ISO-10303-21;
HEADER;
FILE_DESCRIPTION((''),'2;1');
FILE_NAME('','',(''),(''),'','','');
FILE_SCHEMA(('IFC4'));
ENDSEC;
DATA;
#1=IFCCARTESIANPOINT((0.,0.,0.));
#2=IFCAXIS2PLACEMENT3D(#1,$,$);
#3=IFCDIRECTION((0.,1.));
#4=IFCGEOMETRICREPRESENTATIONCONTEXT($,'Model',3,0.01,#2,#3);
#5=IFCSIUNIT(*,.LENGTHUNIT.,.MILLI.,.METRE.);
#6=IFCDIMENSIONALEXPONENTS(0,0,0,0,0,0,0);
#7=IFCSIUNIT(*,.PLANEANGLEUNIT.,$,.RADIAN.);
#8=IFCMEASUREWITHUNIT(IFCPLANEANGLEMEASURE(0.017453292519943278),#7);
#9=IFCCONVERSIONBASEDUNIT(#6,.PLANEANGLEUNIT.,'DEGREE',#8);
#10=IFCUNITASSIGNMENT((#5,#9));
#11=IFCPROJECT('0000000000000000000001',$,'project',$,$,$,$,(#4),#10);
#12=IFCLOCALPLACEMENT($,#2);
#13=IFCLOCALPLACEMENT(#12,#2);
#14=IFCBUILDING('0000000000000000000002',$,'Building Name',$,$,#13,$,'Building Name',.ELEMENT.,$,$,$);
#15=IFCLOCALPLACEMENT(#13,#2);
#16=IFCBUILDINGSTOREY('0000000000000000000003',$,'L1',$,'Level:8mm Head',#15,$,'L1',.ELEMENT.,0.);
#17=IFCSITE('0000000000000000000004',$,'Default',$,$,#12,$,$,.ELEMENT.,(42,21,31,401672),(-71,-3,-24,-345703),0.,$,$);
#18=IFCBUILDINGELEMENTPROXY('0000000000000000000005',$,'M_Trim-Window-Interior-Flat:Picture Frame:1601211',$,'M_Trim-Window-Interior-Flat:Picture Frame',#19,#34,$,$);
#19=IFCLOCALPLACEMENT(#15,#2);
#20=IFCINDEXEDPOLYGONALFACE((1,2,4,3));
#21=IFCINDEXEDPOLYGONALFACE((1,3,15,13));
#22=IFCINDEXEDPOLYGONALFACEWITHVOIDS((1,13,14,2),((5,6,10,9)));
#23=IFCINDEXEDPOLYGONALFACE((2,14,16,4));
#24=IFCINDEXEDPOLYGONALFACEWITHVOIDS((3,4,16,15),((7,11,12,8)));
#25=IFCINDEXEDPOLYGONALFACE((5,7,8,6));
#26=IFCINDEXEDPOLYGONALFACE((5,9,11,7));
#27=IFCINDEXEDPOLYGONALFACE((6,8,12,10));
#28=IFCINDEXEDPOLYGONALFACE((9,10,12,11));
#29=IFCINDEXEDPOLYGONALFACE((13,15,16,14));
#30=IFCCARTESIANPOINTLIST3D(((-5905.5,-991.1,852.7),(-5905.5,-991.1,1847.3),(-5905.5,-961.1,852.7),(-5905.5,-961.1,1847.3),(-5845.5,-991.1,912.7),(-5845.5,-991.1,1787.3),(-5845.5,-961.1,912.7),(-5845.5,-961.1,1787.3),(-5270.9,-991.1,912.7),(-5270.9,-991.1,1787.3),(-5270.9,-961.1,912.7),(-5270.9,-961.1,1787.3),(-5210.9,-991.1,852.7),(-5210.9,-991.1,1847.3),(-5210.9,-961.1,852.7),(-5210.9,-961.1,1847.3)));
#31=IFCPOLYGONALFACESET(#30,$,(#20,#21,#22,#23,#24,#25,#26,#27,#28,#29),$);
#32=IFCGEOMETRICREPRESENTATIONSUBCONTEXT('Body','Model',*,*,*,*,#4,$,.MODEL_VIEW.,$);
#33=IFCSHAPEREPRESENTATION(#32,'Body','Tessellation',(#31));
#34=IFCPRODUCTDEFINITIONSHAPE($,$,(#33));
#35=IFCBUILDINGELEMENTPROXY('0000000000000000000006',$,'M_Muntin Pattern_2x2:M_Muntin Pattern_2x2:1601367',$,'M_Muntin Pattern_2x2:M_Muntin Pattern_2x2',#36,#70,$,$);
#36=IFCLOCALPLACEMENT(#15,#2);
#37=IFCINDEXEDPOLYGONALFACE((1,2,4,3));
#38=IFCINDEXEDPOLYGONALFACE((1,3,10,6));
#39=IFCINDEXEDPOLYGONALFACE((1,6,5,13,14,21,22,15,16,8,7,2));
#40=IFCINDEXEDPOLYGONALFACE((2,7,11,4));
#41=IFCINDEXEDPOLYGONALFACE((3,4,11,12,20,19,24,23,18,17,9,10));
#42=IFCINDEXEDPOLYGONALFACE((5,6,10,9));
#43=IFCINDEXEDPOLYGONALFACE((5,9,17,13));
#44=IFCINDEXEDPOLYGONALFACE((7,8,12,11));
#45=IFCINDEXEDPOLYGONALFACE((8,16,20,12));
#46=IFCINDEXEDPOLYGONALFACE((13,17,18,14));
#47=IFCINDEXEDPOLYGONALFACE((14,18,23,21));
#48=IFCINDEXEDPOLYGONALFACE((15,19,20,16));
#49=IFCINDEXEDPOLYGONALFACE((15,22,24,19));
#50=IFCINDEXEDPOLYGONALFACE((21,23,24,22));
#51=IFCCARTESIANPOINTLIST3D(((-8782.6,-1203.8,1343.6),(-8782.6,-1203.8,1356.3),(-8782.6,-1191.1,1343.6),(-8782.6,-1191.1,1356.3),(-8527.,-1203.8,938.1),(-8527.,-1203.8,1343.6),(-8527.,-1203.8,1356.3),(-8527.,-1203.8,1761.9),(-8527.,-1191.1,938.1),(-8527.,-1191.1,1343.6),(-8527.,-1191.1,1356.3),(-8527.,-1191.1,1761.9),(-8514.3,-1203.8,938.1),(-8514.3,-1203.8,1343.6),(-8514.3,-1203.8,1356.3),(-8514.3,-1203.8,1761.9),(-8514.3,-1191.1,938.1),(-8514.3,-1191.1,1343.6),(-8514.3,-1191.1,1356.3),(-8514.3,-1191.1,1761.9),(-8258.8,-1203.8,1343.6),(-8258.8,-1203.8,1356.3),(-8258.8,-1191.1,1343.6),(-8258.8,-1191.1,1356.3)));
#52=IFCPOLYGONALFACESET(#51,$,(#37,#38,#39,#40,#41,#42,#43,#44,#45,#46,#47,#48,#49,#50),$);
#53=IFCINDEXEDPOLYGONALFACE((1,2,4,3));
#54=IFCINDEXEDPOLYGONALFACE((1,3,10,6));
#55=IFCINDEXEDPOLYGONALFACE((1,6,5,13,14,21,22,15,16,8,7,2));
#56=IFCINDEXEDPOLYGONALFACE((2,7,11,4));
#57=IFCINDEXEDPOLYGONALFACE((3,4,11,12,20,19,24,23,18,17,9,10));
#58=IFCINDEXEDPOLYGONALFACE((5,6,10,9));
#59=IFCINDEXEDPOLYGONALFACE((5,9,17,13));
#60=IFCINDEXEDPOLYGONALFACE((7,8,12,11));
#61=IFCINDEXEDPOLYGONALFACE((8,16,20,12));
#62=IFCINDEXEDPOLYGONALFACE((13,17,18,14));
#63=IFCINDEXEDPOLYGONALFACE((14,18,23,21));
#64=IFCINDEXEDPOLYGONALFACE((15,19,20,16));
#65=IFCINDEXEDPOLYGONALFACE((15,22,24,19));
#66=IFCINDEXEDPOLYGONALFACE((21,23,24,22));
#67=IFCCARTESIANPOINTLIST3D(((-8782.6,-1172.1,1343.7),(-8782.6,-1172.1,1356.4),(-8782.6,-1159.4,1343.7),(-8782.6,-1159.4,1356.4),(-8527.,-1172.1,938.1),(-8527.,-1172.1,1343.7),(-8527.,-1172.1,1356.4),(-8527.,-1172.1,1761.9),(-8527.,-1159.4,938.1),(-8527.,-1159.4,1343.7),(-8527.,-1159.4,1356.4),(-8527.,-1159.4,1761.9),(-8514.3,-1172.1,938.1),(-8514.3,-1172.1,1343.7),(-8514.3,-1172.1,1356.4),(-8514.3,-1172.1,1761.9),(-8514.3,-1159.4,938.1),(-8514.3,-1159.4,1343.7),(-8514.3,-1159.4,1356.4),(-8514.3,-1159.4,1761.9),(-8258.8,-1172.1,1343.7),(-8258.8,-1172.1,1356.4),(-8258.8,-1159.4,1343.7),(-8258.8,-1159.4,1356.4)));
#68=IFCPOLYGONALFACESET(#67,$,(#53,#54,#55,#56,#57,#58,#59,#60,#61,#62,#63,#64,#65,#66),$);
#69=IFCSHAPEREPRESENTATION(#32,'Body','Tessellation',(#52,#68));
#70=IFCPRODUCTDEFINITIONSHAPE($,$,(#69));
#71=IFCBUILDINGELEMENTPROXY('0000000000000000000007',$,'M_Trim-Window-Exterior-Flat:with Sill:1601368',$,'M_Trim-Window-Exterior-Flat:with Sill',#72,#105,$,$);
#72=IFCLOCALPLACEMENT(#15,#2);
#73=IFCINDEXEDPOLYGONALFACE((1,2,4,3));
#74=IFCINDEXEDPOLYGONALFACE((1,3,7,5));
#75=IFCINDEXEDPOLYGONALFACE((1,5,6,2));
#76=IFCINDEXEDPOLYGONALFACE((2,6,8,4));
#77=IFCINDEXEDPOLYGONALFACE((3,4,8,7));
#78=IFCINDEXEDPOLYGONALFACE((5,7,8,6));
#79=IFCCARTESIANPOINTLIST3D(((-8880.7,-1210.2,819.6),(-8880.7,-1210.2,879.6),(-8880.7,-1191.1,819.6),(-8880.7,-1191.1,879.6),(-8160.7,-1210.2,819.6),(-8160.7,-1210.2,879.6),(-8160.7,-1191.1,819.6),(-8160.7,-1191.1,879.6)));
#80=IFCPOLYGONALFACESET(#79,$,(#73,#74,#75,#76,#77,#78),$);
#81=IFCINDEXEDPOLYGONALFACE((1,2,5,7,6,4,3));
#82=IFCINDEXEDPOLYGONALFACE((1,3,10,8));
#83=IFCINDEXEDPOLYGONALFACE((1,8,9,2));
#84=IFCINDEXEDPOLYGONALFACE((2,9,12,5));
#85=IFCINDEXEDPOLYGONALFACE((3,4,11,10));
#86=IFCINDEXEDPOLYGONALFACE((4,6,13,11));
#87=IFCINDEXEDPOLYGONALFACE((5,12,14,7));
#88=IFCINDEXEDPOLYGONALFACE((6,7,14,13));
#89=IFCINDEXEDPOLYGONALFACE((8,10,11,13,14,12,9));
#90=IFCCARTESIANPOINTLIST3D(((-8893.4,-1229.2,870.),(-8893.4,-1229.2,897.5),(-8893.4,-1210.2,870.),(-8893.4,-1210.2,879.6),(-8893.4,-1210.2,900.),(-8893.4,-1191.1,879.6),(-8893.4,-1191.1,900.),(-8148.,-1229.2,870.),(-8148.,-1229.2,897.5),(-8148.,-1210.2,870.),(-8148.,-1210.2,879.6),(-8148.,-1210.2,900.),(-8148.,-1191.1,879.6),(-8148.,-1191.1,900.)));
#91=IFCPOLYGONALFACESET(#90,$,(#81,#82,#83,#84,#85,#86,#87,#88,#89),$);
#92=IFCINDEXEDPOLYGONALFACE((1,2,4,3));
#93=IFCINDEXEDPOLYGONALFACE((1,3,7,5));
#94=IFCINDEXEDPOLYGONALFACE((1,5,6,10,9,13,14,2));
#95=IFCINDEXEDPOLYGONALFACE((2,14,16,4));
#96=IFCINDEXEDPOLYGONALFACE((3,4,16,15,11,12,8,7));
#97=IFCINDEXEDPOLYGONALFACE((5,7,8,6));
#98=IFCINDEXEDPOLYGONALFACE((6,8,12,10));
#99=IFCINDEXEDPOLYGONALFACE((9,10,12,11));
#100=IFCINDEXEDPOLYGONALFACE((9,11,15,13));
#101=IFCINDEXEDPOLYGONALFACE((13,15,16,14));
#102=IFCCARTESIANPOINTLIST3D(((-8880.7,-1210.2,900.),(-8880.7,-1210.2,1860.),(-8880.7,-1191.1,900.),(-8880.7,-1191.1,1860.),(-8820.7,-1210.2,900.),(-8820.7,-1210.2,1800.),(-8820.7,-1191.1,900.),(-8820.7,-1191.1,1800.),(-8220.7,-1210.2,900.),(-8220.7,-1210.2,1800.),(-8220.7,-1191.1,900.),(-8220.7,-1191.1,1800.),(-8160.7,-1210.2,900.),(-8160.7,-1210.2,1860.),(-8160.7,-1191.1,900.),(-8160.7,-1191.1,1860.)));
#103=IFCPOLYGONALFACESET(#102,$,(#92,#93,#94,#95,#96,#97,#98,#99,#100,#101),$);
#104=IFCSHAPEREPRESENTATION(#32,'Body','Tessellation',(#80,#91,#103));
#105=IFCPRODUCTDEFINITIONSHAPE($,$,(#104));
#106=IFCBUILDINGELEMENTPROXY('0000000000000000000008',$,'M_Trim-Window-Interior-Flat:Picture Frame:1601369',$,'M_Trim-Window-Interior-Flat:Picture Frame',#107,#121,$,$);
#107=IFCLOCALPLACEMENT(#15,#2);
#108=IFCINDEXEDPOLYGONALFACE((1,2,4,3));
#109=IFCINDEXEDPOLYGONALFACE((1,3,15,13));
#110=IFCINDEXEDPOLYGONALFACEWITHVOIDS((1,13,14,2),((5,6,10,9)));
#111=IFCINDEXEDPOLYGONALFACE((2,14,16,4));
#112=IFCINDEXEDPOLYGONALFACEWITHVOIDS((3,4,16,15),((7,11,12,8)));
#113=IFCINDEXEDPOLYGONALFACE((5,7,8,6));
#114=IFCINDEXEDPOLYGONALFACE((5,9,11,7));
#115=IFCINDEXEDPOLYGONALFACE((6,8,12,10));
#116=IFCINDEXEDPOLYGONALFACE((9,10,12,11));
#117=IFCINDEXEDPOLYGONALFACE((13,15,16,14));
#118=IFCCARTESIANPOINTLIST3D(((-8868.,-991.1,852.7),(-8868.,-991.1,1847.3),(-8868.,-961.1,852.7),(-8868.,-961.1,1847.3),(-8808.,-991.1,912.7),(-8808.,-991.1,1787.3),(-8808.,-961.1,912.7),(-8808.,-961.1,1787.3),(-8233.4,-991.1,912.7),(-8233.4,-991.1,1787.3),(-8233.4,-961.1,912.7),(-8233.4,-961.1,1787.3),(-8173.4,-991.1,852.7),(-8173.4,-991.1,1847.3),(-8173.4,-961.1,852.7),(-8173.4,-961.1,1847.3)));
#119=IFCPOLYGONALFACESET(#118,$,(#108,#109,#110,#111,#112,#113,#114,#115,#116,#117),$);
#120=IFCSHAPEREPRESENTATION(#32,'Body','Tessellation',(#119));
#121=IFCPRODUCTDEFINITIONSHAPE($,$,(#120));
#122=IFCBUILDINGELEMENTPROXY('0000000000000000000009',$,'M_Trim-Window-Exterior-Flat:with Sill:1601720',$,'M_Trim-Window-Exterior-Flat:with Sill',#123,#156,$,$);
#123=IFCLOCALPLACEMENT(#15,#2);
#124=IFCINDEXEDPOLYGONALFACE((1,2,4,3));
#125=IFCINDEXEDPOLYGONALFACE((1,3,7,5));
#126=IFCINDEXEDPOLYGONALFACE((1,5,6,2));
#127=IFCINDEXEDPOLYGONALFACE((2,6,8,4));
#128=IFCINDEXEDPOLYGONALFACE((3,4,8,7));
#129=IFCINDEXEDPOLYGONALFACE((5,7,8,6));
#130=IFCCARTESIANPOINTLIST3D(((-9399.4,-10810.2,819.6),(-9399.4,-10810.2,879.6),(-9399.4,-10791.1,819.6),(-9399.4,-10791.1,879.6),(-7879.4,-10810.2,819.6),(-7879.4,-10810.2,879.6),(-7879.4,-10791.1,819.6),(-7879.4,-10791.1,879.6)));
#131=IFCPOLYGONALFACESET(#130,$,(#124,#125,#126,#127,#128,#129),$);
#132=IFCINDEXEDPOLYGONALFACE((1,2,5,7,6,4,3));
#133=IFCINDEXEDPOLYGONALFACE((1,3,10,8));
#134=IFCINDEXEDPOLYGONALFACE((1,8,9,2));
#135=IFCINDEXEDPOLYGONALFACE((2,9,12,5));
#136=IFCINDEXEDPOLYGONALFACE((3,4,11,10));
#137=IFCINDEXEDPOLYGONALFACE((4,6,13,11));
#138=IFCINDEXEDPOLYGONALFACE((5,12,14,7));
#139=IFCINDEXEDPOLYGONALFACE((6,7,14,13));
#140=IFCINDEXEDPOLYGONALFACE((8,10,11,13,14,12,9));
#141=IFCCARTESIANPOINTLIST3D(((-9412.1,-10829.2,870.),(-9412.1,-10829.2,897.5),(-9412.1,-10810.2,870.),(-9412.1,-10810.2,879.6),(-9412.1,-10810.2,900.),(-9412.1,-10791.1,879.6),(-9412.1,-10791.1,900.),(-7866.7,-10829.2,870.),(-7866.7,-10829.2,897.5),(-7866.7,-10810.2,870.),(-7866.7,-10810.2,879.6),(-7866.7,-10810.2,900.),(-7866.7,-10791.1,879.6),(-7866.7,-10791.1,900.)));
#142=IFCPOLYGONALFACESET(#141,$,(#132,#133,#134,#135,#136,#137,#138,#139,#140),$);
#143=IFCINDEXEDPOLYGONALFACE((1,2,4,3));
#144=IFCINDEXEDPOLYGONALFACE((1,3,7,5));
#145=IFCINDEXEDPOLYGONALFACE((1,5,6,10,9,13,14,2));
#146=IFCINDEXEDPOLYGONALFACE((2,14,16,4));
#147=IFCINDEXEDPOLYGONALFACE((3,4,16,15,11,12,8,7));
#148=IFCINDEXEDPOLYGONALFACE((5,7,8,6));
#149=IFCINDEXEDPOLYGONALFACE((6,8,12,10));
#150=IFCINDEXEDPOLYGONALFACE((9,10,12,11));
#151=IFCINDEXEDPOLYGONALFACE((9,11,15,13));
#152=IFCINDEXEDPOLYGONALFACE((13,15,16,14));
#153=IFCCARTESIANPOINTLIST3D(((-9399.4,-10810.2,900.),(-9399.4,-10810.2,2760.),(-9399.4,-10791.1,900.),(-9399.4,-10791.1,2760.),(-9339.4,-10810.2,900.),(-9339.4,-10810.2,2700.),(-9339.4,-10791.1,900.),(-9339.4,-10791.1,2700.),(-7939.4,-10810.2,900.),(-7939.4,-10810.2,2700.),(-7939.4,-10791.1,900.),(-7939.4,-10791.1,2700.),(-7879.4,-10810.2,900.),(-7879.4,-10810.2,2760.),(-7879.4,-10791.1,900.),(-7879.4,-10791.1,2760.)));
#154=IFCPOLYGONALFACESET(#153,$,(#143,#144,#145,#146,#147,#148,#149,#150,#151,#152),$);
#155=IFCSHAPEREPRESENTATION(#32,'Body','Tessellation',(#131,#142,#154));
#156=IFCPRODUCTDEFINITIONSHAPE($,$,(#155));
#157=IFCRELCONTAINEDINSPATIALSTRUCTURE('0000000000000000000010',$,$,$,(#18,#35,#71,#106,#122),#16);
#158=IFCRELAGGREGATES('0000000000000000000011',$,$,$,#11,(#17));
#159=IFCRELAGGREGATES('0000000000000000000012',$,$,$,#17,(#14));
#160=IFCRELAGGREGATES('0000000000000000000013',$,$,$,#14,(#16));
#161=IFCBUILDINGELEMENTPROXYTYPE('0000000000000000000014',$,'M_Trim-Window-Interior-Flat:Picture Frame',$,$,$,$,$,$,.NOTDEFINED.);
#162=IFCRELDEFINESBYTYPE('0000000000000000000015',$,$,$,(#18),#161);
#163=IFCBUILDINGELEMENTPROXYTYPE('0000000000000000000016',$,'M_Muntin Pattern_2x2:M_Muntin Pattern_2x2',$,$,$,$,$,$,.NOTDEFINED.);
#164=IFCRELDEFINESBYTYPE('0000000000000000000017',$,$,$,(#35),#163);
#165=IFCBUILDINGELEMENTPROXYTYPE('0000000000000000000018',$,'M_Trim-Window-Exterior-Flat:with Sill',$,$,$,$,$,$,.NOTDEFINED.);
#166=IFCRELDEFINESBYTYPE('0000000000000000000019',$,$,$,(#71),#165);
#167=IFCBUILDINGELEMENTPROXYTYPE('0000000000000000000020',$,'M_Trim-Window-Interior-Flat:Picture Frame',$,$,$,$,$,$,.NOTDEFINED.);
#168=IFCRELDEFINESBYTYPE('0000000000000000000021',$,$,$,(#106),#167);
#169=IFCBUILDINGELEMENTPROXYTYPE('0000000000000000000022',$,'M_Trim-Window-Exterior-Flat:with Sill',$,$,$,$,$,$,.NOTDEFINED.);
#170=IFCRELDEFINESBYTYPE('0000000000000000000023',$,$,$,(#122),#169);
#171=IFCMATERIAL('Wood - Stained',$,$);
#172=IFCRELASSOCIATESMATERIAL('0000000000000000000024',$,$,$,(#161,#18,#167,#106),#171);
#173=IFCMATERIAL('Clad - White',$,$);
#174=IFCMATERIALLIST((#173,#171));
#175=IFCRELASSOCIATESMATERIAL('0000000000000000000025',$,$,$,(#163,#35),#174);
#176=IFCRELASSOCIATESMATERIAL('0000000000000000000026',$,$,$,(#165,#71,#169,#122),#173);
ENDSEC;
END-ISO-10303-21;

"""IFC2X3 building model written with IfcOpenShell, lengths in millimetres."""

from ifc_helpers import new_model, entity, si_unit, converted_unit, direction, frame, frame_2d, origin, place, context, subcontext, project, spatial, polyline, rectangle, outline, extrude, source, transform, mapped, material, material_list, type_object, type_shapes, element, save


model = new_model("IFC2X3")

# Units and contexts
model_context = context("Model", 3, precision=0.01, world=origin(), true_north=direction((0.0, 1.0)))
body_context = subcontext(model_context, "Body", "Model", "MODEL_VIEW")
ifc_project = project(units=[si_unit("LENGTHUNIT", "METRE", prefix="MILLI"), converted_unit("PLANEANGLEUNIT", "DEGREE", entity("IfcPlaneAngleMeasure", 0.017453292519943278), si_unit("PLANEANGLEUNIT", "RADIAN"), dimensions=[0, 0, 0, 0, 0, 0, 0])], contexts=[model_context])

# Site, building, storey
site_placement = place(None, origin())
site = spatial("IfcSite", under=ifc_project, at=site_placement, Name="Default", CompositionType="ELEMENT", RefLatitude=(42, 21, 31, 401672), RefLongitude=(-71, -3, -24, -345703), RefElevation=0.0)
building_placement = place(site_placement, origin())
building = spatial("IfcBuilding", under=site, at=building_placement, Name="Building Name", LongName="Building Name", CompositionType="ELEMENT")
storey_placement = place(building_placement, origin())
storey = spatial("IfcBuildingStorey", under=building, at=storey_placement, Name="L1", ObjectType="Level:8mm Head", LongName="L1", CompositionType="ELEMENT", Elevation=0.0)

# Building element proxies
ifc_material_1 = material(Name="Clad - White")
ifc_material_2 = material(Name="Wood - Stained")
ifc_material_list = material_list([ifc_material_1, ifc_material_2])
building_element_proxy_type_1 = type_object("IfcBuildingElementProxyType", Name="M_Trim-Window-Interior-Flat:Picture Frame", PredefinedType="NOTDEFINED", material=ifc_material_2)
shared_shape_1 = source(origin(), body_context, "Body", "SweptSolid", [
    extrude(outline(polyline([(-497.3, -347.3), (497.3, -347.3), (497.3, 347.3), (-497.3, 347.3), (-497.3, -347.3)]), holes=[polyline([(-437.3, -287.3), (-437.3, 287.3), (437.3, 287.3), (437.3, -287.3), (-437.3, -287.3)])]), frame((0.0, 450.0, 0.0), z_axis=(0.0, 0.0, 1.0), x_axis=(0.0, 1.0, 0.0)), (0.0, 0.0, 1.0), 30.0),
])
type_shapes(building_element_proxy_type_1, [shared_shape_1])
proxy_1_placement = place(storey_placement, frame((-5558.2, -991.1, 1800.0), z_axis=(0.0, 1.0, 0.0), x_axis=(1.0, 0.0, 0.0)))
element("IfcBuildingElementProxy", 1, at=proxy_1_placement, inside=storey, type_object=building_element_proxy_type_1, material=ifc_material_2, Name="M_Trim-Window-Interior-Flat:Picture Frame:1601211", ObjectType="M_Trim-Window-Interior-Flat:Picture Frame", context=body_context, shape_type="MappedRepresentation", body=[
    mapped(shared_shape_1, transform((0.0, 0.0, 0.0), scale=1.0)),
])
building_element_proxy_type_2 = type_object("IfcBuildingElementProxyType", Name="M_Muntin Pattern_2x2:M_Muntin Pattern_2x2", PredefinedType="NOTDEFINED", material=ifc_material_list)
shared_shape_2 = source(origin(), body_context, "Body", "SweptSolid", [
    extrude(outline(polyline([(6.4, -6.4), (411.9, -6.4), (411.9, 6.3), (6.4, 6.3), (6.4, 261.9), (-6.3, 261.9), (-6.3, 6.3), (-411.9, 6.3), (-411.9, -6.4), (-6.3, -6.4), (-6.3, -261.9), (6.4, -261.9), (6.4, -6.4)])), frame((0.0, -22.2, 411.9), z_axis=(0.0, 1.0, 0.0), x_axis=(0.0, 0.0, 1.0)), (0.0, 0.0, 1.0), 12.7),
    extrude(outline(polyline([(6.4, -6.4), (411.9, -6.4), (411.9, 6.3), (6.4, 6.3), (6.4, 261.9), (-6.3, 261.9), (-6.3, 6.3), (-411.9, 6.3), (-411.9, -6.4), (-6.3, -6.4), (-6.3, -261.9), (6.4, -261.9), (6.4, -6.4)])), frame((0.0, 9.5, 411.9), z_axis=(0.0, 1.0, 0.0), x_axis=(0.0, 0.0, 1.0)), (0.0, 0.0, 1.0), 12.7),
])
type_shapes(building_element_proxy_type_2, [shared_shape_2])
proxy_2_placement = place(storey_placement, frame((-8520.7, -1181.6, 938.1)))
element("IfcBuildingElementProxy", 2, at=proxy_2_placement, inside=storey, type_object=building_element_proxy_type_2, material=ifc_material_list, Name="M_Muntin Pattern_2x2:M_Muntin Pattern_2x2:1601367", ObjectType="M_Muntin Pattern_2x2:M_Muntin Pattern_2x2", context=body_context, shape_type="MappedRepresentation", body=[
    mapped(shared_shape_2, transform((0.0, 0.0, 0.0), scale=1.0)),
])
building_element_proxy_type_3 = type_object("IfcBuildingElementProxyType", Name="M_Trim-Window-Exterior-Flat:with Sill", PredefinedType="NOTDEFINED", material=ifc_material_1)
shared_shape_3 = source(origin(), body_context, "Body", "SweptSolid", [
    extrude(rectangle(XDim=720.0, YDim=60.0, at=frame_2d((0.0, 0.0), x_axis=(1.0, 0.0))), frame((0.0, -950.4, 0.0), z_axis=(0.0, 0.0, 1.0), x_axis=(-1.0, 0.0, 0.0)), (0.0, 0.0, 1.0), 19.0),
    extrude(outline(polyline([(-19.0, -15.2), (0.0, -15.2), (0.0, -5.7), (19.0, -5.7), (19.0, 14.8), (0.0, 14.8), (-19.0, 12.3), (-19.0, -15.2)])), frame((-372.7, -914.8, 19.0), z_axis=(1.0, 0.0, 0.0), x_axis=(0.0, 0.0, -1.0)), (0.0, 0.0, 1.0), 745.4),
    extrude(outline(polyline([(-495.0, -360.0), (465.0, -360.0), (465.0, -300.0), (-435.0, -300.0), (-435.0, 300.0), (465.0, 300.0), (465.0, 360.0), (-495.0, 360.0), (-495.0, -360.0)])), frame((0.0, -435.0, 0.0), z_axis=(0.0, 0.0, 1.0), x_axis=(0.0, -1.0, 0.0)), (0.0, 0.0, 1.0), 19.0),
])
type_shapes(building_element_proxy_type_3, [shared_shape_3])
proxy_3_placement = place(storey_placement, frame((-8520.7, -1191.1, 1800.0), z_axis=(0.0, -1.0, 0.0), x_axis=(1.0, 0.0, 0.0)))
element("IfcBuildingElementProxy", 3, at=proxy_3_placement, inside=storey, type_object=building_element_proxy_type_3, material=ifc_material_1, Name="M_Trim-Window-Exterior-Flat:with Sill:1601368", ObjectType="M_Trim-Window-Exterior-Flat:with Sill", context=body_context, shape_type="MappedRepresentation", body=[
    mapped(shared_shape_3, transform((0.0, 0.0, 0.0), scale=1.0)),
])
building_element_proxy_type_4 = type_object("IfcBuildingElementProxyType", Name="M_Trim-Window-Interior-Flat:Picture Frame", PredefinedType="NOTDEFINED", material=ifc_material_2)
shared_shape_4 = source(origin(), body_context, "Body", "SweptSolid", [
    extrude(outline(polyline([(-347.3, -497.3), (347.3, -497.3), (347.3, 497.3), (-347.3, 497.3), (-347.3, -497.3)]), holes=[polyline([(-287.3, -437.3), (-287.3, 437.3), (287.3, 437.3), (287.3, -437.3), (-287.3, -437.3)])]), frame((0.0, -450.0, 0.0), z_axis=(0.0, 0.0, 1.0), x_axis=(-1.0, 0.0, 0.0)), (0.0, 0.0, 1.0), 30.0),
])
type_shapes(building_element_proxy_type_4, [shared_shape_4])
proxy_4_placement = place(storey_placement, frame((-8520.7, -991.1, 1800.0), z_axis=(0.0, 1.0, 0.0), x_axis=(-1.0, 0.0, 0.0)))
element("IfcBuildingElementProxy", 4, at=proxy_4_placement, inside=storey, type_object=building_element_proxy_type_4, material=ifc_material_2, Name="M_Trim-Window-Interior-Flat:Picture Frame:1601369", ObjectType="M_Trim-Window-Interior-Flat:Picture Frame", context=body_context, shape_type="MappedRepresentation", body=[
    mapped(shared_shape_4, transform((0.0, 0.0, 0.0), scale=1.0)),
])
building_element_proxy_type_5 = type_object("IfcBuildingElementProxyType", Name="M_Trim-Window-Exterior-Flat:with Sill", PredefinedType="NOTDEFINED", material=ifc_material_1)
shared_shape_5 = source(origin(), body_context, "Body", "SweptSolid", [
    extrude(rectangle(XDim=60.0, YDim=1520.0, at=frame_2d((0.0, 0.0), x_axis=(1.0, 0.0))), frame((0.0, 1850.4, 0.0), z_axis=(0.0, 0.0, 1.0), x_axis=(0.0, 1.0, 0.0)), (0.0, 0.0, 1.0), 19.0),
    extrude(outline(polyline([(-15.2, -19.0), (12.3, -19.0), (14.8, 0.0), (14.8, 19.0), (-5.7, 19.0), (-5.7, 0.0), (-15.2, 0.0), (-15.2, -19.0)])), frame((-772.7, 1814.8, 19.0), z_axis=(1.0, 0.0, 0.0), x_axis=(0.0, -1.0, 0.0)), (0.0, 0.0, 1.0), 1545.4),
    extrude(outline(polyline([(-760.0, -945.0), (760.0, -945.0), (760.0, 915.0), (700.0, 915.0), (700.0, -885.0), (-700.0, -885.0), (-700.0, 915.0), (-760.0, 915.0), (-760.0, -945.0)])), frame((0.0, 885.0, 0.0)), (0.0, 0.0, 1.0), 19.0),
])
type_shapes(building_element_proxy_type_5, [shared_shape_5])
proxy_5_placement = place(storey_placement, frame((-8639.4, -10791.1, 2700.0), z_axis=(0.0, -1.0, 0.0), x_axis=(-1.0, 0.0, 0.0)))
element("IfcBuildingElementProxy", 5, at=proxy_5_placement, inside=storey, type_object=building_element_proxy_type_5, material=ifc_material_1, Name="M_Trim-Window-Exterior-Flat:with Sill:1601720", ObjectType="M_Trim-Window-Exterior-Flat:with Sill", context=body_context, shape_type="MappedRepresentation", body=[
    mapped(shared_shape_5, transform((0.0, 0.0, 0.0), scale=1.0)),
])

save(model, "model.ifc")
